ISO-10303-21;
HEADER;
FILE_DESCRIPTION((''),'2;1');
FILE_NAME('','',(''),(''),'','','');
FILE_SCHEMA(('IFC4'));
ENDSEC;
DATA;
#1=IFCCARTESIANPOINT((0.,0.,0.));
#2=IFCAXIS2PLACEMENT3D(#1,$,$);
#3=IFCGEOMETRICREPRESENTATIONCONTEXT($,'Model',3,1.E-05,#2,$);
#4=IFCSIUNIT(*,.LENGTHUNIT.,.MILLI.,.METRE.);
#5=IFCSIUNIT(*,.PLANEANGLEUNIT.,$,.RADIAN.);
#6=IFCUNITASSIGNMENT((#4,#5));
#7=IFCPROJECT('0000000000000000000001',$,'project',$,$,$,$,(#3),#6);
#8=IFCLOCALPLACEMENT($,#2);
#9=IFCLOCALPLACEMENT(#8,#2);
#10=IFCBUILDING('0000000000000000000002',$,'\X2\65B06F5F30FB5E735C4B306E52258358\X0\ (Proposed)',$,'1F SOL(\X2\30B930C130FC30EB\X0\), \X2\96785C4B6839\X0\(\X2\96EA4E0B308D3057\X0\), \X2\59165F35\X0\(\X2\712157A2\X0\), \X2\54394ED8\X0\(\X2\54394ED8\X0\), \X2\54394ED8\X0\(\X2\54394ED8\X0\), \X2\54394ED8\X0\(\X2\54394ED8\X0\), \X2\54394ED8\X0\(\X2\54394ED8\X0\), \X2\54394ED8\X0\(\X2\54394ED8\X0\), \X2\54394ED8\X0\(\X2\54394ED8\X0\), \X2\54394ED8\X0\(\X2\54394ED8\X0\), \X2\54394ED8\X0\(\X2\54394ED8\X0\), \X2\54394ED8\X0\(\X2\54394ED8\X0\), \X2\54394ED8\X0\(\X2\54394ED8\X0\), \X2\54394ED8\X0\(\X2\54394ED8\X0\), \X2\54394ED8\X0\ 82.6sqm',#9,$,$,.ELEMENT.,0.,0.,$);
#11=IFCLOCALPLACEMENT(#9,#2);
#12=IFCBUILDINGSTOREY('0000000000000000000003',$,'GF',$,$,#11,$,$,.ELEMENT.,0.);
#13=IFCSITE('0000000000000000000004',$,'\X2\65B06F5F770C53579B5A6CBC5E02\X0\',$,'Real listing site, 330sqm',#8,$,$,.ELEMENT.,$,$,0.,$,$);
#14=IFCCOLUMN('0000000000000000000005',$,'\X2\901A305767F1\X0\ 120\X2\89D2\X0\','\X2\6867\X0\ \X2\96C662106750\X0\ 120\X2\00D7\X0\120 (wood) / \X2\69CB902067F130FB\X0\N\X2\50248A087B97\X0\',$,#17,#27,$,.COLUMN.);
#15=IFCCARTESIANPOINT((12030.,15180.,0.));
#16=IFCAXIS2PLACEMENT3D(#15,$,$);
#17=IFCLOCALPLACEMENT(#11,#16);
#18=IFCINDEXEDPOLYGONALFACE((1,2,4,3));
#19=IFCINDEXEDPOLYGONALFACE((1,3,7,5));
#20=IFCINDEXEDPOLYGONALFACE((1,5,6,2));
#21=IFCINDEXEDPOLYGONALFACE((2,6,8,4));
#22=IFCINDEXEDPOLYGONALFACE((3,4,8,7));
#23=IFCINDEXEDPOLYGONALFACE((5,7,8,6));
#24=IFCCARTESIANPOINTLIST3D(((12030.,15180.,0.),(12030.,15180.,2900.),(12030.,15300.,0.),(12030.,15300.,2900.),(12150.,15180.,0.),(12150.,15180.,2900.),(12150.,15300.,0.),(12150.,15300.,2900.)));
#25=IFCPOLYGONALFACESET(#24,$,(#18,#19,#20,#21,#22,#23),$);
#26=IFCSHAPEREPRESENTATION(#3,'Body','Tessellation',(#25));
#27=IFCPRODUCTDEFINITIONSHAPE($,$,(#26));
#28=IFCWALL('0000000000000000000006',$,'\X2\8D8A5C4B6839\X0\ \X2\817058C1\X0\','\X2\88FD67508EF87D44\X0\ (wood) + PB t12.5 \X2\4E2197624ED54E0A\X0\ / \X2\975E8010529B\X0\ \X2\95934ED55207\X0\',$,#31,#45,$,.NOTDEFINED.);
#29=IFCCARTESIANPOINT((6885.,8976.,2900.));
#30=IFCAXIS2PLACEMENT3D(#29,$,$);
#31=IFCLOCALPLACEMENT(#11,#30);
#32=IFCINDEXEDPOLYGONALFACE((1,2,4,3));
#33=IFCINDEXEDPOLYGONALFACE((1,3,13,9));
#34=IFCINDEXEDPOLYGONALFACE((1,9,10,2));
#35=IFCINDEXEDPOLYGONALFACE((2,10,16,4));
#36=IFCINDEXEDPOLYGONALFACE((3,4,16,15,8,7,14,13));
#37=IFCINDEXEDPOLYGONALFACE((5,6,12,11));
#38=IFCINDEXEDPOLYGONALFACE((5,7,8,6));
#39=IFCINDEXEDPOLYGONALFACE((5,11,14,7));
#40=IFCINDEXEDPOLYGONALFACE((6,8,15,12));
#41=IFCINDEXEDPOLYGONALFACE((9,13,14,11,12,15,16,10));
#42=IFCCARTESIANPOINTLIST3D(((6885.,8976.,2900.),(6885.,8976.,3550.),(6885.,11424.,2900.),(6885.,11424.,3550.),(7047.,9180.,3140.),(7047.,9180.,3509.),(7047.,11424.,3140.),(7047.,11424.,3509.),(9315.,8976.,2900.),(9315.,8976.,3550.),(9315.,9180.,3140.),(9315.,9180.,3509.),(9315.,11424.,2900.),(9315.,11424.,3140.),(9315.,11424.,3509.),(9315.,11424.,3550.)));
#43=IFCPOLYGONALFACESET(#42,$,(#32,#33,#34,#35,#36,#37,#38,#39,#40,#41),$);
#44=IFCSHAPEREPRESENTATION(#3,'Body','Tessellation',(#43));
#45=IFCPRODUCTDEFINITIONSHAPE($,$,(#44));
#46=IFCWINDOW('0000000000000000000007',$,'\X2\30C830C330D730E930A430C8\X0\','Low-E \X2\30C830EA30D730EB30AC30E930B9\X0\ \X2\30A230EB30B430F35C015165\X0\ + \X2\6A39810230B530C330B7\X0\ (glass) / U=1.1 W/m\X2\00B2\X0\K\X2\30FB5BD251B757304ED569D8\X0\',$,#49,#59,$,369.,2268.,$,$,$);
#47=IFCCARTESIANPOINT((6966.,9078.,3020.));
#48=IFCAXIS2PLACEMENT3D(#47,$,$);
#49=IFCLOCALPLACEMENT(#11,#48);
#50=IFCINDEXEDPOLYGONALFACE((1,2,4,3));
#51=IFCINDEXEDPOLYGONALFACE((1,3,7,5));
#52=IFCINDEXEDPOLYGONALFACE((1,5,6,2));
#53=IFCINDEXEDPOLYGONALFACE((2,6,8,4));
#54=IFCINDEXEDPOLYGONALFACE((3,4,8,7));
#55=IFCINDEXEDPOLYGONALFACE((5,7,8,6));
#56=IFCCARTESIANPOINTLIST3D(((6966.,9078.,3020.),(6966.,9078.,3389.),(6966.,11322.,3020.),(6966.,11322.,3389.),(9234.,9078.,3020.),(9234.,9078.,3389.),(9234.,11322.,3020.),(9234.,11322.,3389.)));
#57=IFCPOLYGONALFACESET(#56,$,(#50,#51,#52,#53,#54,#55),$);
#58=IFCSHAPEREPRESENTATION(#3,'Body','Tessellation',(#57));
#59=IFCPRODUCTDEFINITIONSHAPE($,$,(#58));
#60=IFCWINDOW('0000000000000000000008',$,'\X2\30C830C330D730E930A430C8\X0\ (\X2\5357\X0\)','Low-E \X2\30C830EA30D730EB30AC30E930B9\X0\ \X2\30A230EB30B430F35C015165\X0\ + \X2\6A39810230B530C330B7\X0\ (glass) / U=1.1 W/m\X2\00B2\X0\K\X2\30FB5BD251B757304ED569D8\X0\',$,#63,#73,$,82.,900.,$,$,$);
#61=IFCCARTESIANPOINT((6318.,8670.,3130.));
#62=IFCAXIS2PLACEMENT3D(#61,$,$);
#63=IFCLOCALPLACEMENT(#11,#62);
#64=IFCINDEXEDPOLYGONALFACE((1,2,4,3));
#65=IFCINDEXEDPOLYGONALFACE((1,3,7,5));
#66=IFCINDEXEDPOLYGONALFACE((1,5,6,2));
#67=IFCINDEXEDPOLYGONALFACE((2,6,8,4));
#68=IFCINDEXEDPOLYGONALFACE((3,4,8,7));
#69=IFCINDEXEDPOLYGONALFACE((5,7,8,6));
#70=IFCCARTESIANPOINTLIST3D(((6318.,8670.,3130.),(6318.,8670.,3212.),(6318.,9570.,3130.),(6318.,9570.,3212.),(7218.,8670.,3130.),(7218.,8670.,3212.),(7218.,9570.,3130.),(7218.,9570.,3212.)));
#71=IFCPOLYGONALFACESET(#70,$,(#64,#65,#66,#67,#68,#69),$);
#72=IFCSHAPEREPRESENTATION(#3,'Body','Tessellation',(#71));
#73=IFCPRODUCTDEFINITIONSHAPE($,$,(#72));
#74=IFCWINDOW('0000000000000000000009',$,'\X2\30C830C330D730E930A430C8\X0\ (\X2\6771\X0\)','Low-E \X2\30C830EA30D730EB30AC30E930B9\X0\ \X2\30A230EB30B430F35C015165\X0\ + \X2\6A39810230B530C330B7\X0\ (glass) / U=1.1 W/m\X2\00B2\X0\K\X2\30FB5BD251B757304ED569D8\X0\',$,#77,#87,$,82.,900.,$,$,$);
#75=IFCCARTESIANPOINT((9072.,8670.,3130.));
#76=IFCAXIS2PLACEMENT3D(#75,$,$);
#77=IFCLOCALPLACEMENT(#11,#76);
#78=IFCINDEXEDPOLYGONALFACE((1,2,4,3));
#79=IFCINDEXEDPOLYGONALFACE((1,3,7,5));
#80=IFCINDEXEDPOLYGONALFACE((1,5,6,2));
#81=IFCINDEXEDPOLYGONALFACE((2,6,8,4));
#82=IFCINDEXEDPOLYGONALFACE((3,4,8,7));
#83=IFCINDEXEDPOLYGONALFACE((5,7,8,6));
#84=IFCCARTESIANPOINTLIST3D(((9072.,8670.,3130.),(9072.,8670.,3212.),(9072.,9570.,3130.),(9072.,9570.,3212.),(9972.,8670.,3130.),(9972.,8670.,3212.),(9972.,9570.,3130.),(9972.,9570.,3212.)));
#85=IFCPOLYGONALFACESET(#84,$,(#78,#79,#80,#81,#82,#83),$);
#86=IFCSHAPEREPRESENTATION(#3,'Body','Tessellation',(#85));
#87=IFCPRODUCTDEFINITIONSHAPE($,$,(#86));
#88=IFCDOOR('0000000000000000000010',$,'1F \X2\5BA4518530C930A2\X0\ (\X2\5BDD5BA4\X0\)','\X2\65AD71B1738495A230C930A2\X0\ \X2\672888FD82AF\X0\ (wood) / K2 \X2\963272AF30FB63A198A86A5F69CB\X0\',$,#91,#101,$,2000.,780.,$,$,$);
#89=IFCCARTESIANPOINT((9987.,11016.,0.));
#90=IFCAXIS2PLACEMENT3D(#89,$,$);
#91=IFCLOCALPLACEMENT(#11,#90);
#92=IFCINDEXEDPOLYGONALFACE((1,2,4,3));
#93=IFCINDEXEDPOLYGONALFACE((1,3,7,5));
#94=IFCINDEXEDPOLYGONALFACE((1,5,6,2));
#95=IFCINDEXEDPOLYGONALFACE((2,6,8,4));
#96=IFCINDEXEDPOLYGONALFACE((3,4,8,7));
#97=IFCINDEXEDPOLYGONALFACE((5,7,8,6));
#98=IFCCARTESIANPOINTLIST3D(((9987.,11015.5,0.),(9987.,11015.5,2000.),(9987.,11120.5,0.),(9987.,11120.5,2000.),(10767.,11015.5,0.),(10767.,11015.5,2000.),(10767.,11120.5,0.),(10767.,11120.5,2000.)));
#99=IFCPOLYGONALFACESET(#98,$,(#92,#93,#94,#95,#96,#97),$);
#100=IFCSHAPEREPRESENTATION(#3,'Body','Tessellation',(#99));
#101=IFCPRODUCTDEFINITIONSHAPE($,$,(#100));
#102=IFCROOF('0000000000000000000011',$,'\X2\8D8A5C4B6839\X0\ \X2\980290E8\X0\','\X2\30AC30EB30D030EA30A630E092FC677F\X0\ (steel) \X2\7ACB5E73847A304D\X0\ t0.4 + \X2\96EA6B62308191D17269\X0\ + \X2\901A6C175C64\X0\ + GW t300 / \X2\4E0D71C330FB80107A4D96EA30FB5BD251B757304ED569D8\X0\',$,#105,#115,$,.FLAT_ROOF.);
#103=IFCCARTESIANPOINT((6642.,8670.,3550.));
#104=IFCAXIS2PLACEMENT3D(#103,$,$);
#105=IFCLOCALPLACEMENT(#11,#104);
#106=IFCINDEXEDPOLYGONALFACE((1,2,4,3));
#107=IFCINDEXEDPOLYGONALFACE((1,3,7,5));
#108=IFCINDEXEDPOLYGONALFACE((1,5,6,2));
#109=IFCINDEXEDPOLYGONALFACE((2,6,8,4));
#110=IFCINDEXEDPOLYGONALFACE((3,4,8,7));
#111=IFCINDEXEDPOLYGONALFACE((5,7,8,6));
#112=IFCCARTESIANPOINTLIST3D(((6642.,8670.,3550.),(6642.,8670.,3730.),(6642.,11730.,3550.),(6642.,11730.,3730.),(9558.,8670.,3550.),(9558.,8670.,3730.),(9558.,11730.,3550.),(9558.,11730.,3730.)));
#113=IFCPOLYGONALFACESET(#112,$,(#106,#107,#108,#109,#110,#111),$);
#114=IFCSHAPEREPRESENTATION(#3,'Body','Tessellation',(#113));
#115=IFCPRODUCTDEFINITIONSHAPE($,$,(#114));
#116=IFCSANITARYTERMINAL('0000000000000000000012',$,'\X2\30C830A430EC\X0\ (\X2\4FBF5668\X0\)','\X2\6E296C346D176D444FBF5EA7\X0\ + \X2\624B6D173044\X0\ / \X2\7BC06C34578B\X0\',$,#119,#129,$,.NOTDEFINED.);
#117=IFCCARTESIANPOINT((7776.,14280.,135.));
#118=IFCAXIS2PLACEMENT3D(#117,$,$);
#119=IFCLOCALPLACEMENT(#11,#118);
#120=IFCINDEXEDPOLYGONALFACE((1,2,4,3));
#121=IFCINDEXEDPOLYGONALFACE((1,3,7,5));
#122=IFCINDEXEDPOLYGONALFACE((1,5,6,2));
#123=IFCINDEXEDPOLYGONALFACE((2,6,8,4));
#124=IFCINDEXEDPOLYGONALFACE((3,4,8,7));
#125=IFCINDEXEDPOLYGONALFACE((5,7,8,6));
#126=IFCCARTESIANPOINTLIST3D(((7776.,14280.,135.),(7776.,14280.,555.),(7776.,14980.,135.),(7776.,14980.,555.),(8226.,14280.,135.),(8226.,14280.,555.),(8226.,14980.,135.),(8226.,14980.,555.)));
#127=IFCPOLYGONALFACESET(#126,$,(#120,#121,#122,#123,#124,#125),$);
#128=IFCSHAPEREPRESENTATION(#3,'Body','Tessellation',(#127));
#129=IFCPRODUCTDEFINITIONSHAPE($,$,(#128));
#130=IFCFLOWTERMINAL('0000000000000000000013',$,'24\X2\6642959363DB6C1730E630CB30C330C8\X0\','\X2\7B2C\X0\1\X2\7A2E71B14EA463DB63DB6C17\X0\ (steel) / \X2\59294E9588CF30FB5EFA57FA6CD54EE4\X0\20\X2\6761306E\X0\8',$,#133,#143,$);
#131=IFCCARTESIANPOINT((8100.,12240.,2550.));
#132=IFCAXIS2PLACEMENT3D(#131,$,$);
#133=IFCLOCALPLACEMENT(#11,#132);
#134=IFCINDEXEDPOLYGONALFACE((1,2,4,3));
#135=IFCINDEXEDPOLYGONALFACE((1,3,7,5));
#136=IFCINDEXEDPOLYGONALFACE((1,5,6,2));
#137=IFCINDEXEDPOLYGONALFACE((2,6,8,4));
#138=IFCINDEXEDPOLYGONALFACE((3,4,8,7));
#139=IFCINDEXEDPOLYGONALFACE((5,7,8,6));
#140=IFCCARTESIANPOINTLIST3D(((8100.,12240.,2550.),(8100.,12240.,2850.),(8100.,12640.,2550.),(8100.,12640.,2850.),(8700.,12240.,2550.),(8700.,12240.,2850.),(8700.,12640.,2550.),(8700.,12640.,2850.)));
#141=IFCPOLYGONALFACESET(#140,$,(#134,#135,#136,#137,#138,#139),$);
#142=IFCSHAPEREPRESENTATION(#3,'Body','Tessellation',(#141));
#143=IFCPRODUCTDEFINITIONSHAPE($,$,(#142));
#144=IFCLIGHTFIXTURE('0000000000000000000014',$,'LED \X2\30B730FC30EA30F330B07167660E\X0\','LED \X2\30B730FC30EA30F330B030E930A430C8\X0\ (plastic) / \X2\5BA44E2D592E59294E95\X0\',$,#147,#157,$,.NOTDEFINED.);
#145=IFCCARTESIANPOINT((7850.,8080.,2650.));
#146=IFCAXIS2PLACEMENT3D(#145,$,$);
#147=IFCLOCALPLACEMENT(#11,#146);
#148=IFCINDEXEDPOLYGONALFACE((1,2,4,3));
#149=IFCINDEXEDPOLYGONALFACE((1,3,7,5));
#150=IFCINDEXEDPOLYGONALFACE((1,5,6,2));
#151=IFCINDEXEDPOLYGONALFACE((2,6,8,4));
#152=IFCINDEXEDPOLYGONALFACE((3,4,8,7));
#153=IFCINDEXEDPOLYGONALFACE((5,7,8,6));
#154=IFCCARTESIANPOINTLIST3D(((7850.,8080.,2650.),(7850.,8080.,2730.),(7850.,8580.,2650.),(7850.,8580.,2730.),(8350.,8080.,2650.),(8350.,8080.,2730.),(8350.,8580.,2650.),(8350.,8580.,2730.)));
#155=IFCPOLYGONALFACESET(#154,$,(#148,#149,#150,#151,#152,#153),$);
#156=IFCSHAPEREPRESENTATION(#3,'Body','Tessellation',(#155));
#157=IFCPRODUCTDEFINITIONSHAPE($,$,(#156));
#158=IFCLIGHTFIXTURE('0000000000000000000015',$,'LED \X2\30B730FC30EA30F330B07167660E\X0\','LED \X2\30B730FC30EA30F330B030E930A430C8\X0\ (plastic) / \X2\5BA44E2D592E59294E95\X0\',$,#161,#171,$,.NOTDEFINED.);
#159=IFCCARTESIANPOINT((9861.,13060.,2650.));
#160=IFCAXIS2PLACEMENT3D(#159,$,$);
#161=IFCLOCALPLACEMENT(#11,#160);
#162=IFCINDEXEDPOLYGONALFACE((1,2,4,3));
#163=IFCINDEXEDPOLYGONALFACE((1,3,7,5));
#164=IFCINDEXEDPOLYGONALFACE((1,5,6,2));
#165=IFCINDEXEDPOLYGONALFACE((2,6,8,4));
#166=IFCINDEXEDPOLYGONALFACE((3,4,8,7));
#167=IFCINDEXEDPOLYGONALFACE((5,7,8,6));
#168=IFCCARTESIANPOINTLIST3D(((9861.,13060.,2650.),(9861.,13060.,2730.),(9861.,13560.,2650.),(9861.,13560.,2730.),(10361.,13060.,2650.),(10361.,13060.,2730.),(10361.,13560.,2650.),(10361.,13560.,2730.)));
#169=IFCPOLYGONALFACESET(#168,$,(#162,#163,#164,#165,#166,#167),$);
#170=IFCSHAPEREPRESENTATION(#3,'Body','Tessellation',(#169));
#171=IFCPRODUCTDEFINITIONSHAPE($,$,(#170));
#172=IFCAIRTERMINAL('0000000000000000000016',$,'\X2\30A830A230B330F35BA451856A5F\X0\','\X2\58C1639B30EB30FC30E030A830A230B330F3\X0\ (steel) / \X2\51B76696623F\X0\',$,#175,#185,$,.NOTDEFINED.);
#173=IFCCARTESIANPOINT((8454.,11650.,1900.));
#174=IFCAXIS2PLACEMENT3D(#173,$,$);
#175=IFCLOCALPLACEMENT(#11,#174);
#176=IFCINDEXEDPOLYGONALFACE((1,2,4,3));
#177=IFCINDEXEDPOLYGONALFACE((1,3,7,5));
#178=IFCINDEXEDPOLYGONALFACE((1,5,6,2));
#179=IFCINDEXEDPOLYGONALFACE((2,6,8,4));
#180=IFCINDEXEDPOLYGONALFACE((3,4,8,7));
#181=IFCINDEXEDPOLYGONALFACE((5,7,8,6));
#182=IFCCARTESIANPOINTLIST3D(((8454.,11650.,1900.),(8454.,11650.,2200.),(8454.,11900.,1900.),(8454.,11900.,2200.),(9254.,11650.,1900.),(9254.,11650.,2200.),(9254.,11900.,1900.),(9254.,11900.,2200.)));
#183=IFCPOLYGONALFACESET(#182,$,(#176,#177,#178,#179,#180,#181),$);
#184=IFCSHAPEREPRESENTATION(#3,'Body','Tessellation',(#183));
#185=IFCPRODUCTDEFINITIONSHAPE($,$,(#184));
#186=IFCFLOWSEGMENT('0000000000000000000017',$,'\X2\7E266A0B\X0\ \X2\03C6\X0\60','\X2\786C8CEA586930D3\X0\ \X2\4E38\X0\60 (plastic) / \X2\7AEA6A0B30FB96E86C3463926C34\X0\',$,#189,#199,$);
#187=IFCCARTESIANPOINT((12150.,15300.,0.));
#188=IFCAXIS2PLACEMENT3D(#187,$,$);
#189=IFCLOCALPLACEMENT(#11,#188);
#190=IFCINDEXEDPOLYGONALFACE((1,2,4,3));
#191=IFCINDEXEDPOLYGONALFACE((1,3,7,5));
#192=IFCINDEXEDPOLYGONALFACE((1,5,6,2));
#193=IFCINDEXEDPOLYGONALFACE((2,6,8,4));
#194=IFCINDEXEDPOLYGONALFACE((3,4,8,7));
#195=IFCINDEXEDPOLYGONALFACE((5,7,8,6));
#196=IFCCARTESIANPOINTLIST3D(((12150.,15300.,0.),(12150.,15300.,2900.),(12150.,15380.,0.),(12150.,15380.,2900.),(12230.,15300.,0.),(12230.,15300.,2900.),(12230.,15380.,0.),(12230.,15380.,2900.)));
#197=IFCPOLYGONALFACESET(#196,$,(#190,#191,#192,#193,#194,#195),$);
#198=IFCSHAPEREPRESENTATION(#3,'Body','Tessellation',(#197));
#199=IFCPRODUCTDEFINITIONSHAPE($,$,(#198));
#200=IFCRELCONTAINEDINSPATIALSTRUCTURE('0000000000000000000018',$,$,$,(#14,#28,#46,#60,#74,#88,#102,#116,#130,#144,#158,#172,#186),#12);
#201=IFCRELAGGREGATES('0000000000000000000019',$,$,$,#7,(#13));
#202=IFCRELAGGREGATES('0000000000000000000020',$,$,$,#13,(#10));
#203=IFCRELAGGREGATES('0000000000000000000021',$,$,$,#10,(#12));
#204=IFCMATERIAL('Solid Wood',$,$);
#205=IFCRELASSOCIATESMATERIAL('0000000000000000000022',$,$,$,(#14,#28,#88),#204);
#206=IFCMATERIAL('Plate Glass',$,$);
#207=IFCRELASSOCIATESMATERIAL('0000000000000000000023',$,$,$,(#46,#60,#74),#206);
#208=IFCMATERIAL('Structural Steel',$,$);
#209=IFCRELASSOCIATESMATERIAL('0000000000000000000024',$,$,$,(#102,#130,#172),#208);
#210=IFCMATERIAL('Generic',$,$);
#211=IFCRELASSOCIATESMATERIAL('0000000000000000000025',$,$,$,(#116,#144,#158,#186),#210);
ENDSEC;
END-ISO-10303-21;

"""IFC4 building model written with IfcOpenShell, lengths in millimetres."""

from ifc_helpers import new_model, si_unit, frame, frame_2d, origin, place, context, project, spatial, rectangle, extrude, material, element, fill, save


model = new_model("IFC4")

# Units and contexts
model_context = context("Model", 3, precision=1e-05, world=origin())
ifc_project = project(units=[si_unit("LENGTHUNIT", "METRE", prefix="MILLI"), si_unit("PLANEANGLEUNIT", "RADIAN")], contexts=[model_context])

# Site, building, storey
site_placement = place(None, origin())
site = spatial("IfcSite", under=ifc_project, at=site_placement, Name="新潟県南魚沼市", ObjectType="Real listing site, 330sqm", CompositionType="ELEMENT", RefElevation=0.0)
building_placement = place(site_placement, origin())
building = spatial("IfcBuilding", under=site, at=building_placement, Name="新潟・平屋の別荘 (Proposed)", ObjectType="1F SOL(スチール), 陸屋根(雪下ろし), 外張(無垢), 吹付(吹付), 吹付(吹付), 吹付(吹付), 吹付(吹付), 吹付(吹付), 吹付(吹付), 吹付(吹付), 吹付(吹付), 吹付(吹付), 吹付(吹付), 吹付(吹付), 吹付 82.6sqm", CompositionType="ELEMENT", ElevationOfRefHeight=0.0, ElevationOfTerrain=0.0)
storey_placement = place(building_placement, origin())
storey = spatial("IfcBuildingStorey", under=building, at=storey_placement, Name="GF", CompositionType="ELEMENT", Elevation=0.0)

# Column
ifc_material_1 = material(Name="Solid Wood")
column_1_placement = place(storey_placement, frame((12030.0, 15180.0, 0.0)))
element("IfcColumn", 1, at=column_1_placement, inside=storey, material=ifc_material_1, Name="通し柱 120角", Description="桧 集成材 120×120 (wood) / 構造柱・N値計算", PredefinedType="COLUMN", context=model_context, shape_type="SweptSolid", body=[
    extrude(rectangle(XDim=120.0, YDim=120.0, at=frame_2d((60.0, 60.0))), frame((12030.0, 15180.0, 0.0)), (0.0, 0.0, 1.0), 2900.0),
])

# Wall, openings, windows
wall_1_placement = place(storey_placement, frame((6885.0, 8976.0, 2900.0)))
wall_1 = element("IfcWall", 2, at=wall_1_placement, inside=storey, material=ifc_material_1, Name="越屋根 腰壁", Description="製材軸組 (wood) + PB t12.5 両面仕上 / 非耐力 間仕切", PredefinedType="NOTDEFINED", context=model_context, shape_type="SweptSolid", body=[
    extrude(rectangle(XDim=2430.0, YDim=2448.0, at=frame_2d((1215.0, 1224.0))), frame((6885.0, 8976.0, 2900.0)), (0.0, 0.0, 1.0), 650.0),
])
opening_1_placement = place(storey_placement, frame((6966.0, 9078.0, 3020.0)))
opening_1 = element("IfcOpeningElement", 3, at=opening_1_placement, cuts=wall_1, PredefinedType="NOTDEFINED", context=model_context, shape_type="SweptSolid", body=[
    extrude(rectangle(XDim=2268.0, YDim=2244.0, at=frame_2d((1134.0, 1122.0))), frame((6966.0, 9078.0, 3020.0)), (0.0, 0.0, 1.0), 369.0),
])
opening_2_placement = place(storey_placement, frame((6318.0, 8670.0, 3130.0)))
opening_2 = element("IfcOpeningElement", 4, at=opening_2_placement, cuts=wall_1, PredefinedType="NOTDEFINED", context=model_context, shape_type="SweptSolid", body=[
    extrude(rectangle(XDim=900.0, YDim=900.0, at=frame_2d((450.0, 450.0))), frame((6318.0, 8670.0, 3130.0)), (0.0, 0.0, 1.0), 82.0),
])
opening_3_placement = place(storey_placement, frame((9072.0, 8670.0, 3130.0)))
opening_3 = element("IfcOpeningElement", 5, at=opening_3_placement, cuts=wall_1, PredefinedType="NOTDEFINED", context=model_context, shape_type="SweptSolid", body=[
    extrude(rectangle(XDim=900.0, YDim=900.0, at=frame_2d((450.0, 450.0))), frame((9072.0, 8670.0, 3130.0)), (0.0, 0.0, 1.0), 82.0),
])
ifc_material_2 = material(Name="Plate Glass")
window_1_placement = place(storey_placement, frame((6966.0, 9078.0, 3020.0)))
window_1 = element("IfcWindow", 6, at=window_1_placement, inside=storey, material=ifc_material_2, Name="トップライト", Description="Low-E トリプルガラス アルゴン封入 + 樹脂サッシ (glass) / U=1.1 W/m²K・寒冷地仕様", OverallHeight=369.0, OverallWidth=2268.0, context=model_context, shape_type="SweptSolid", body=[
    extrude(rectangle(XDim=2268.0, YDim=2244.0, at=frame_2d((1134.0, 1122.0))), frame((6966.0, 9078.0, 3020.0)), (0.0, 0.0, 1.0), 369.0),
])
fill(opening_1, window_1)
window_2_placement = place(storey_placement, frame((6318.0, 8670.0, 3130.0)))
window_2 = element("IfcWindow", 7, at=window_2_placement, inside=storey, material=ifc_material_2, Name="トップライト (南)", Description="Low-E トリプルガラス アルゴン封入 + 樹脂サッシ (glass) / U=1.1 W/m²K・寒冷地仕様", OverallHeight=82.0, OverallWidth=900.0, context=model_context, shape_type="SweptSolid", body=[
    extrude(rectangle(XDim=900.0, YDim=900.0, at=frame_2d((450.0, 450.0))), frame((6318.0, 8670.0, 3130.0)), (0.0, 0.0, 1.0), 82.0),
])
fill(opening_2, window_2)
window_3_placement = place(storey_placement, frame((9072.0, 8670.0, 3130.0)))
window_3 = element("IfcWindow", 8, at=window_3_placement, inside=storey, material=ifc_material_2, Name="トップライト (東)", Description="Low-E トリプルガラス アルゴン封入 + 樹脂サッシ (glass) / U=1.1 W/m²K・寒冷地仕様", OverallHeight=82.0, OverallWidth=900.0, context=model_context, shape_type="SweptSolid", body=[
    extrude(rectangle(XDim=900.0, YDim=900.0, at=frame_2d((450.0, 450.0))), frame((9072.0, 8670.0, 3130.0)), (0.0, 0.0, 1.0), 82.0),
])
fill(opening_3, window_3)

# Door
door_placement = place(storey_placement, frame((9987.0, 11016.0, 0.0)))
element("IfcDoor", 9, at=door_placement, inside=storey, material=ifc_material_1, Name="1F 室内ドア (寝室)", Description="断熱玄関ドア 木製芯 (wood) / K2 防犯・採風機構", OverallHeight=2000.0, OverallWidth=780.0, context=model_context, shape_type="SweptSolid", body=[
    extrude(rectangle(XDim=780.0, YDim=105.0, at=frame_2d((390.0, 52.0))), frame((9987.0, 11016.0, 0.0)), (0.0, 0.0, 1.0), 2000.0),
])

# Roof
ifc_material_3 = material(Name="Structural Steel")
roof_placement = place(storey_placement, frame((6642.0, 8670.0, 3550.0)))
element("IfcRoof", 10, at=roof_placement, inside=storey, material=ifc_material_3, Name="越屋根 頂部", Description="ガルバリウム鋼板 (steel) 立平葺き t0.4 + 雪止め金物 + 通気層 + GW t300 / 不燃・耐積雪・寒冷地仕様", PredefinedType="FLAT_ROOF", context=model_context, shape_type="SweptSolid", body=[
    extrude(rectangle(XDim=2916.0, YDim=3060.0, at=frame_2d((1458.0, 1530.0))), frame((6642.0, 8670.0, 3550.0)), (0.0, 0.0, 1.0), 180.0),
])

# Sanitary terminal
ifc_material_4 = material(Name="Generic")
sanitary_terminal_placement = place(storey_placement, frame((7776.0, 14280.0, 135.0)))
element("IfcSanitaryTerminal", 11, at=sanitary_terminal_placement, inside=storey, material=ifc_material_4, Name="トイレ (便器)", Description="温水洗浄便座 + 手洗い / 節水型", PredefinedType="NOTDEFINED", context=model_context, shape_type="SweptSolid", body=[
    extrude(rectangle(XDim=450.0, YDim=700.0, at=frame_2d((225.0, 350.0))), frame((7776.0, 14280.0, 135.0)), (0.0, 0.0, 1.0), 420.0),
])

# Flow terminal
flow_terminal_placement = place(storey_placement, frame((8100.0, 12240.0, 2550.0)))
element("IfcFlowTerminal", 12, at=flow_terminal_placement, inside=storey, material=ifc_material_3, Name="24時間換気ユニット", Description="第1種熱交換換気 (steel) / 天井裏・建基法令20条の8", context=model_context, shape_type="SweptSolid", body=[
    extrude(rectangle(XDim=600.0, YDim=400.0, at=frame_2d((300.0, 200.0))), frame((8100.0, 12240.0, 2550.0)), (0.0, 0.0, 1.0), 300.0),
])

# Light fixtures
light_fixture_1_placement = place(storey_placement, frame((7850.0, 8080.0, 2650.0)))
element("IfcLightFixture", 13, at=light_fixture_1_placement, inside=storey, material=ifc_material_4, Name="LED シーリング照明", Description="LED シーリングライト (plastic) / 室中央天井", PredefinedType="NOTDEFINED", context=model_context, shape_type="SweptSolid", body=[
    extrude(rectangle(XDim=500.0, YDim=500.0, at=frame_2d((250.0, 250.0))), frame((7850.0, 8080.0, 2650.0)), (0.0, 0.0, 1.0), 80.0),
])
light_fixture_2_placement = place(storey_placement, frame((9861.0, 13060.0, 2650.0)))
element("IfcLightFixture", 14, at=light_fixture_2_placement, inside=storey, material=ifc_material_4, Name="LED シーリング照明", Description="LED シーリングライト (plastic) / 室中央天井", PredefinedType="NOTDEFINED", context=model_context, shape_type="SweptSolid", body=[
    extrude(rectangle(XDim=500.0, YDim=500.0, at=frame_2d((250.0, 250.0))), frame((9861.0, 13060.0, 2650.0)), (0.0, 0.0, 1.0), 80.0),
])

# Air terminal
air_terminal_placement = place(storey_placement, frame((8454.0, 11650.0, 1900.0)))
element("IfcAirTerminal", 15, at=air_terminal_placement, inside=storey, material=ifc_material_3, Name="エアコン室内機", Description="壁掛ルームエアコン (steel) / 冷暖房", PredefinedType="NOTDEFINED", context=model_context, shape_type="SweptSolid", body=[
    extrude(rectangle(XDim=800.0, YDim=250.0, at=frame_2d((400.0, 125.0))), frame((8454.0, 11650.0, 1900.0)), (0.0, 0.0, 1.0), 300.0),
])

# Flow segment
flow_segment_placement = place(storey_placement, frame((12150.0, 15300.0, 0.0)))
element("IfcFlowSegment", 16, at=flow_segment_placement, inside=storey, material=ifc_material_4, Name="縦樋 φ60", Description="硬質塩ビ 丸60 (plastic) / 竪樋・雨水排水", context=model_context, shape_type="SweptSolid", body=[
    extrude(rectangle(XDim=80.0, YDim=80.0, at=frame_2d((40.0, 40.0))), frame((12150.0, 15300.0, 0.0)), (0.0, 0.0, 1.0), 2900.0),
])

save(model, "model.ifc")
